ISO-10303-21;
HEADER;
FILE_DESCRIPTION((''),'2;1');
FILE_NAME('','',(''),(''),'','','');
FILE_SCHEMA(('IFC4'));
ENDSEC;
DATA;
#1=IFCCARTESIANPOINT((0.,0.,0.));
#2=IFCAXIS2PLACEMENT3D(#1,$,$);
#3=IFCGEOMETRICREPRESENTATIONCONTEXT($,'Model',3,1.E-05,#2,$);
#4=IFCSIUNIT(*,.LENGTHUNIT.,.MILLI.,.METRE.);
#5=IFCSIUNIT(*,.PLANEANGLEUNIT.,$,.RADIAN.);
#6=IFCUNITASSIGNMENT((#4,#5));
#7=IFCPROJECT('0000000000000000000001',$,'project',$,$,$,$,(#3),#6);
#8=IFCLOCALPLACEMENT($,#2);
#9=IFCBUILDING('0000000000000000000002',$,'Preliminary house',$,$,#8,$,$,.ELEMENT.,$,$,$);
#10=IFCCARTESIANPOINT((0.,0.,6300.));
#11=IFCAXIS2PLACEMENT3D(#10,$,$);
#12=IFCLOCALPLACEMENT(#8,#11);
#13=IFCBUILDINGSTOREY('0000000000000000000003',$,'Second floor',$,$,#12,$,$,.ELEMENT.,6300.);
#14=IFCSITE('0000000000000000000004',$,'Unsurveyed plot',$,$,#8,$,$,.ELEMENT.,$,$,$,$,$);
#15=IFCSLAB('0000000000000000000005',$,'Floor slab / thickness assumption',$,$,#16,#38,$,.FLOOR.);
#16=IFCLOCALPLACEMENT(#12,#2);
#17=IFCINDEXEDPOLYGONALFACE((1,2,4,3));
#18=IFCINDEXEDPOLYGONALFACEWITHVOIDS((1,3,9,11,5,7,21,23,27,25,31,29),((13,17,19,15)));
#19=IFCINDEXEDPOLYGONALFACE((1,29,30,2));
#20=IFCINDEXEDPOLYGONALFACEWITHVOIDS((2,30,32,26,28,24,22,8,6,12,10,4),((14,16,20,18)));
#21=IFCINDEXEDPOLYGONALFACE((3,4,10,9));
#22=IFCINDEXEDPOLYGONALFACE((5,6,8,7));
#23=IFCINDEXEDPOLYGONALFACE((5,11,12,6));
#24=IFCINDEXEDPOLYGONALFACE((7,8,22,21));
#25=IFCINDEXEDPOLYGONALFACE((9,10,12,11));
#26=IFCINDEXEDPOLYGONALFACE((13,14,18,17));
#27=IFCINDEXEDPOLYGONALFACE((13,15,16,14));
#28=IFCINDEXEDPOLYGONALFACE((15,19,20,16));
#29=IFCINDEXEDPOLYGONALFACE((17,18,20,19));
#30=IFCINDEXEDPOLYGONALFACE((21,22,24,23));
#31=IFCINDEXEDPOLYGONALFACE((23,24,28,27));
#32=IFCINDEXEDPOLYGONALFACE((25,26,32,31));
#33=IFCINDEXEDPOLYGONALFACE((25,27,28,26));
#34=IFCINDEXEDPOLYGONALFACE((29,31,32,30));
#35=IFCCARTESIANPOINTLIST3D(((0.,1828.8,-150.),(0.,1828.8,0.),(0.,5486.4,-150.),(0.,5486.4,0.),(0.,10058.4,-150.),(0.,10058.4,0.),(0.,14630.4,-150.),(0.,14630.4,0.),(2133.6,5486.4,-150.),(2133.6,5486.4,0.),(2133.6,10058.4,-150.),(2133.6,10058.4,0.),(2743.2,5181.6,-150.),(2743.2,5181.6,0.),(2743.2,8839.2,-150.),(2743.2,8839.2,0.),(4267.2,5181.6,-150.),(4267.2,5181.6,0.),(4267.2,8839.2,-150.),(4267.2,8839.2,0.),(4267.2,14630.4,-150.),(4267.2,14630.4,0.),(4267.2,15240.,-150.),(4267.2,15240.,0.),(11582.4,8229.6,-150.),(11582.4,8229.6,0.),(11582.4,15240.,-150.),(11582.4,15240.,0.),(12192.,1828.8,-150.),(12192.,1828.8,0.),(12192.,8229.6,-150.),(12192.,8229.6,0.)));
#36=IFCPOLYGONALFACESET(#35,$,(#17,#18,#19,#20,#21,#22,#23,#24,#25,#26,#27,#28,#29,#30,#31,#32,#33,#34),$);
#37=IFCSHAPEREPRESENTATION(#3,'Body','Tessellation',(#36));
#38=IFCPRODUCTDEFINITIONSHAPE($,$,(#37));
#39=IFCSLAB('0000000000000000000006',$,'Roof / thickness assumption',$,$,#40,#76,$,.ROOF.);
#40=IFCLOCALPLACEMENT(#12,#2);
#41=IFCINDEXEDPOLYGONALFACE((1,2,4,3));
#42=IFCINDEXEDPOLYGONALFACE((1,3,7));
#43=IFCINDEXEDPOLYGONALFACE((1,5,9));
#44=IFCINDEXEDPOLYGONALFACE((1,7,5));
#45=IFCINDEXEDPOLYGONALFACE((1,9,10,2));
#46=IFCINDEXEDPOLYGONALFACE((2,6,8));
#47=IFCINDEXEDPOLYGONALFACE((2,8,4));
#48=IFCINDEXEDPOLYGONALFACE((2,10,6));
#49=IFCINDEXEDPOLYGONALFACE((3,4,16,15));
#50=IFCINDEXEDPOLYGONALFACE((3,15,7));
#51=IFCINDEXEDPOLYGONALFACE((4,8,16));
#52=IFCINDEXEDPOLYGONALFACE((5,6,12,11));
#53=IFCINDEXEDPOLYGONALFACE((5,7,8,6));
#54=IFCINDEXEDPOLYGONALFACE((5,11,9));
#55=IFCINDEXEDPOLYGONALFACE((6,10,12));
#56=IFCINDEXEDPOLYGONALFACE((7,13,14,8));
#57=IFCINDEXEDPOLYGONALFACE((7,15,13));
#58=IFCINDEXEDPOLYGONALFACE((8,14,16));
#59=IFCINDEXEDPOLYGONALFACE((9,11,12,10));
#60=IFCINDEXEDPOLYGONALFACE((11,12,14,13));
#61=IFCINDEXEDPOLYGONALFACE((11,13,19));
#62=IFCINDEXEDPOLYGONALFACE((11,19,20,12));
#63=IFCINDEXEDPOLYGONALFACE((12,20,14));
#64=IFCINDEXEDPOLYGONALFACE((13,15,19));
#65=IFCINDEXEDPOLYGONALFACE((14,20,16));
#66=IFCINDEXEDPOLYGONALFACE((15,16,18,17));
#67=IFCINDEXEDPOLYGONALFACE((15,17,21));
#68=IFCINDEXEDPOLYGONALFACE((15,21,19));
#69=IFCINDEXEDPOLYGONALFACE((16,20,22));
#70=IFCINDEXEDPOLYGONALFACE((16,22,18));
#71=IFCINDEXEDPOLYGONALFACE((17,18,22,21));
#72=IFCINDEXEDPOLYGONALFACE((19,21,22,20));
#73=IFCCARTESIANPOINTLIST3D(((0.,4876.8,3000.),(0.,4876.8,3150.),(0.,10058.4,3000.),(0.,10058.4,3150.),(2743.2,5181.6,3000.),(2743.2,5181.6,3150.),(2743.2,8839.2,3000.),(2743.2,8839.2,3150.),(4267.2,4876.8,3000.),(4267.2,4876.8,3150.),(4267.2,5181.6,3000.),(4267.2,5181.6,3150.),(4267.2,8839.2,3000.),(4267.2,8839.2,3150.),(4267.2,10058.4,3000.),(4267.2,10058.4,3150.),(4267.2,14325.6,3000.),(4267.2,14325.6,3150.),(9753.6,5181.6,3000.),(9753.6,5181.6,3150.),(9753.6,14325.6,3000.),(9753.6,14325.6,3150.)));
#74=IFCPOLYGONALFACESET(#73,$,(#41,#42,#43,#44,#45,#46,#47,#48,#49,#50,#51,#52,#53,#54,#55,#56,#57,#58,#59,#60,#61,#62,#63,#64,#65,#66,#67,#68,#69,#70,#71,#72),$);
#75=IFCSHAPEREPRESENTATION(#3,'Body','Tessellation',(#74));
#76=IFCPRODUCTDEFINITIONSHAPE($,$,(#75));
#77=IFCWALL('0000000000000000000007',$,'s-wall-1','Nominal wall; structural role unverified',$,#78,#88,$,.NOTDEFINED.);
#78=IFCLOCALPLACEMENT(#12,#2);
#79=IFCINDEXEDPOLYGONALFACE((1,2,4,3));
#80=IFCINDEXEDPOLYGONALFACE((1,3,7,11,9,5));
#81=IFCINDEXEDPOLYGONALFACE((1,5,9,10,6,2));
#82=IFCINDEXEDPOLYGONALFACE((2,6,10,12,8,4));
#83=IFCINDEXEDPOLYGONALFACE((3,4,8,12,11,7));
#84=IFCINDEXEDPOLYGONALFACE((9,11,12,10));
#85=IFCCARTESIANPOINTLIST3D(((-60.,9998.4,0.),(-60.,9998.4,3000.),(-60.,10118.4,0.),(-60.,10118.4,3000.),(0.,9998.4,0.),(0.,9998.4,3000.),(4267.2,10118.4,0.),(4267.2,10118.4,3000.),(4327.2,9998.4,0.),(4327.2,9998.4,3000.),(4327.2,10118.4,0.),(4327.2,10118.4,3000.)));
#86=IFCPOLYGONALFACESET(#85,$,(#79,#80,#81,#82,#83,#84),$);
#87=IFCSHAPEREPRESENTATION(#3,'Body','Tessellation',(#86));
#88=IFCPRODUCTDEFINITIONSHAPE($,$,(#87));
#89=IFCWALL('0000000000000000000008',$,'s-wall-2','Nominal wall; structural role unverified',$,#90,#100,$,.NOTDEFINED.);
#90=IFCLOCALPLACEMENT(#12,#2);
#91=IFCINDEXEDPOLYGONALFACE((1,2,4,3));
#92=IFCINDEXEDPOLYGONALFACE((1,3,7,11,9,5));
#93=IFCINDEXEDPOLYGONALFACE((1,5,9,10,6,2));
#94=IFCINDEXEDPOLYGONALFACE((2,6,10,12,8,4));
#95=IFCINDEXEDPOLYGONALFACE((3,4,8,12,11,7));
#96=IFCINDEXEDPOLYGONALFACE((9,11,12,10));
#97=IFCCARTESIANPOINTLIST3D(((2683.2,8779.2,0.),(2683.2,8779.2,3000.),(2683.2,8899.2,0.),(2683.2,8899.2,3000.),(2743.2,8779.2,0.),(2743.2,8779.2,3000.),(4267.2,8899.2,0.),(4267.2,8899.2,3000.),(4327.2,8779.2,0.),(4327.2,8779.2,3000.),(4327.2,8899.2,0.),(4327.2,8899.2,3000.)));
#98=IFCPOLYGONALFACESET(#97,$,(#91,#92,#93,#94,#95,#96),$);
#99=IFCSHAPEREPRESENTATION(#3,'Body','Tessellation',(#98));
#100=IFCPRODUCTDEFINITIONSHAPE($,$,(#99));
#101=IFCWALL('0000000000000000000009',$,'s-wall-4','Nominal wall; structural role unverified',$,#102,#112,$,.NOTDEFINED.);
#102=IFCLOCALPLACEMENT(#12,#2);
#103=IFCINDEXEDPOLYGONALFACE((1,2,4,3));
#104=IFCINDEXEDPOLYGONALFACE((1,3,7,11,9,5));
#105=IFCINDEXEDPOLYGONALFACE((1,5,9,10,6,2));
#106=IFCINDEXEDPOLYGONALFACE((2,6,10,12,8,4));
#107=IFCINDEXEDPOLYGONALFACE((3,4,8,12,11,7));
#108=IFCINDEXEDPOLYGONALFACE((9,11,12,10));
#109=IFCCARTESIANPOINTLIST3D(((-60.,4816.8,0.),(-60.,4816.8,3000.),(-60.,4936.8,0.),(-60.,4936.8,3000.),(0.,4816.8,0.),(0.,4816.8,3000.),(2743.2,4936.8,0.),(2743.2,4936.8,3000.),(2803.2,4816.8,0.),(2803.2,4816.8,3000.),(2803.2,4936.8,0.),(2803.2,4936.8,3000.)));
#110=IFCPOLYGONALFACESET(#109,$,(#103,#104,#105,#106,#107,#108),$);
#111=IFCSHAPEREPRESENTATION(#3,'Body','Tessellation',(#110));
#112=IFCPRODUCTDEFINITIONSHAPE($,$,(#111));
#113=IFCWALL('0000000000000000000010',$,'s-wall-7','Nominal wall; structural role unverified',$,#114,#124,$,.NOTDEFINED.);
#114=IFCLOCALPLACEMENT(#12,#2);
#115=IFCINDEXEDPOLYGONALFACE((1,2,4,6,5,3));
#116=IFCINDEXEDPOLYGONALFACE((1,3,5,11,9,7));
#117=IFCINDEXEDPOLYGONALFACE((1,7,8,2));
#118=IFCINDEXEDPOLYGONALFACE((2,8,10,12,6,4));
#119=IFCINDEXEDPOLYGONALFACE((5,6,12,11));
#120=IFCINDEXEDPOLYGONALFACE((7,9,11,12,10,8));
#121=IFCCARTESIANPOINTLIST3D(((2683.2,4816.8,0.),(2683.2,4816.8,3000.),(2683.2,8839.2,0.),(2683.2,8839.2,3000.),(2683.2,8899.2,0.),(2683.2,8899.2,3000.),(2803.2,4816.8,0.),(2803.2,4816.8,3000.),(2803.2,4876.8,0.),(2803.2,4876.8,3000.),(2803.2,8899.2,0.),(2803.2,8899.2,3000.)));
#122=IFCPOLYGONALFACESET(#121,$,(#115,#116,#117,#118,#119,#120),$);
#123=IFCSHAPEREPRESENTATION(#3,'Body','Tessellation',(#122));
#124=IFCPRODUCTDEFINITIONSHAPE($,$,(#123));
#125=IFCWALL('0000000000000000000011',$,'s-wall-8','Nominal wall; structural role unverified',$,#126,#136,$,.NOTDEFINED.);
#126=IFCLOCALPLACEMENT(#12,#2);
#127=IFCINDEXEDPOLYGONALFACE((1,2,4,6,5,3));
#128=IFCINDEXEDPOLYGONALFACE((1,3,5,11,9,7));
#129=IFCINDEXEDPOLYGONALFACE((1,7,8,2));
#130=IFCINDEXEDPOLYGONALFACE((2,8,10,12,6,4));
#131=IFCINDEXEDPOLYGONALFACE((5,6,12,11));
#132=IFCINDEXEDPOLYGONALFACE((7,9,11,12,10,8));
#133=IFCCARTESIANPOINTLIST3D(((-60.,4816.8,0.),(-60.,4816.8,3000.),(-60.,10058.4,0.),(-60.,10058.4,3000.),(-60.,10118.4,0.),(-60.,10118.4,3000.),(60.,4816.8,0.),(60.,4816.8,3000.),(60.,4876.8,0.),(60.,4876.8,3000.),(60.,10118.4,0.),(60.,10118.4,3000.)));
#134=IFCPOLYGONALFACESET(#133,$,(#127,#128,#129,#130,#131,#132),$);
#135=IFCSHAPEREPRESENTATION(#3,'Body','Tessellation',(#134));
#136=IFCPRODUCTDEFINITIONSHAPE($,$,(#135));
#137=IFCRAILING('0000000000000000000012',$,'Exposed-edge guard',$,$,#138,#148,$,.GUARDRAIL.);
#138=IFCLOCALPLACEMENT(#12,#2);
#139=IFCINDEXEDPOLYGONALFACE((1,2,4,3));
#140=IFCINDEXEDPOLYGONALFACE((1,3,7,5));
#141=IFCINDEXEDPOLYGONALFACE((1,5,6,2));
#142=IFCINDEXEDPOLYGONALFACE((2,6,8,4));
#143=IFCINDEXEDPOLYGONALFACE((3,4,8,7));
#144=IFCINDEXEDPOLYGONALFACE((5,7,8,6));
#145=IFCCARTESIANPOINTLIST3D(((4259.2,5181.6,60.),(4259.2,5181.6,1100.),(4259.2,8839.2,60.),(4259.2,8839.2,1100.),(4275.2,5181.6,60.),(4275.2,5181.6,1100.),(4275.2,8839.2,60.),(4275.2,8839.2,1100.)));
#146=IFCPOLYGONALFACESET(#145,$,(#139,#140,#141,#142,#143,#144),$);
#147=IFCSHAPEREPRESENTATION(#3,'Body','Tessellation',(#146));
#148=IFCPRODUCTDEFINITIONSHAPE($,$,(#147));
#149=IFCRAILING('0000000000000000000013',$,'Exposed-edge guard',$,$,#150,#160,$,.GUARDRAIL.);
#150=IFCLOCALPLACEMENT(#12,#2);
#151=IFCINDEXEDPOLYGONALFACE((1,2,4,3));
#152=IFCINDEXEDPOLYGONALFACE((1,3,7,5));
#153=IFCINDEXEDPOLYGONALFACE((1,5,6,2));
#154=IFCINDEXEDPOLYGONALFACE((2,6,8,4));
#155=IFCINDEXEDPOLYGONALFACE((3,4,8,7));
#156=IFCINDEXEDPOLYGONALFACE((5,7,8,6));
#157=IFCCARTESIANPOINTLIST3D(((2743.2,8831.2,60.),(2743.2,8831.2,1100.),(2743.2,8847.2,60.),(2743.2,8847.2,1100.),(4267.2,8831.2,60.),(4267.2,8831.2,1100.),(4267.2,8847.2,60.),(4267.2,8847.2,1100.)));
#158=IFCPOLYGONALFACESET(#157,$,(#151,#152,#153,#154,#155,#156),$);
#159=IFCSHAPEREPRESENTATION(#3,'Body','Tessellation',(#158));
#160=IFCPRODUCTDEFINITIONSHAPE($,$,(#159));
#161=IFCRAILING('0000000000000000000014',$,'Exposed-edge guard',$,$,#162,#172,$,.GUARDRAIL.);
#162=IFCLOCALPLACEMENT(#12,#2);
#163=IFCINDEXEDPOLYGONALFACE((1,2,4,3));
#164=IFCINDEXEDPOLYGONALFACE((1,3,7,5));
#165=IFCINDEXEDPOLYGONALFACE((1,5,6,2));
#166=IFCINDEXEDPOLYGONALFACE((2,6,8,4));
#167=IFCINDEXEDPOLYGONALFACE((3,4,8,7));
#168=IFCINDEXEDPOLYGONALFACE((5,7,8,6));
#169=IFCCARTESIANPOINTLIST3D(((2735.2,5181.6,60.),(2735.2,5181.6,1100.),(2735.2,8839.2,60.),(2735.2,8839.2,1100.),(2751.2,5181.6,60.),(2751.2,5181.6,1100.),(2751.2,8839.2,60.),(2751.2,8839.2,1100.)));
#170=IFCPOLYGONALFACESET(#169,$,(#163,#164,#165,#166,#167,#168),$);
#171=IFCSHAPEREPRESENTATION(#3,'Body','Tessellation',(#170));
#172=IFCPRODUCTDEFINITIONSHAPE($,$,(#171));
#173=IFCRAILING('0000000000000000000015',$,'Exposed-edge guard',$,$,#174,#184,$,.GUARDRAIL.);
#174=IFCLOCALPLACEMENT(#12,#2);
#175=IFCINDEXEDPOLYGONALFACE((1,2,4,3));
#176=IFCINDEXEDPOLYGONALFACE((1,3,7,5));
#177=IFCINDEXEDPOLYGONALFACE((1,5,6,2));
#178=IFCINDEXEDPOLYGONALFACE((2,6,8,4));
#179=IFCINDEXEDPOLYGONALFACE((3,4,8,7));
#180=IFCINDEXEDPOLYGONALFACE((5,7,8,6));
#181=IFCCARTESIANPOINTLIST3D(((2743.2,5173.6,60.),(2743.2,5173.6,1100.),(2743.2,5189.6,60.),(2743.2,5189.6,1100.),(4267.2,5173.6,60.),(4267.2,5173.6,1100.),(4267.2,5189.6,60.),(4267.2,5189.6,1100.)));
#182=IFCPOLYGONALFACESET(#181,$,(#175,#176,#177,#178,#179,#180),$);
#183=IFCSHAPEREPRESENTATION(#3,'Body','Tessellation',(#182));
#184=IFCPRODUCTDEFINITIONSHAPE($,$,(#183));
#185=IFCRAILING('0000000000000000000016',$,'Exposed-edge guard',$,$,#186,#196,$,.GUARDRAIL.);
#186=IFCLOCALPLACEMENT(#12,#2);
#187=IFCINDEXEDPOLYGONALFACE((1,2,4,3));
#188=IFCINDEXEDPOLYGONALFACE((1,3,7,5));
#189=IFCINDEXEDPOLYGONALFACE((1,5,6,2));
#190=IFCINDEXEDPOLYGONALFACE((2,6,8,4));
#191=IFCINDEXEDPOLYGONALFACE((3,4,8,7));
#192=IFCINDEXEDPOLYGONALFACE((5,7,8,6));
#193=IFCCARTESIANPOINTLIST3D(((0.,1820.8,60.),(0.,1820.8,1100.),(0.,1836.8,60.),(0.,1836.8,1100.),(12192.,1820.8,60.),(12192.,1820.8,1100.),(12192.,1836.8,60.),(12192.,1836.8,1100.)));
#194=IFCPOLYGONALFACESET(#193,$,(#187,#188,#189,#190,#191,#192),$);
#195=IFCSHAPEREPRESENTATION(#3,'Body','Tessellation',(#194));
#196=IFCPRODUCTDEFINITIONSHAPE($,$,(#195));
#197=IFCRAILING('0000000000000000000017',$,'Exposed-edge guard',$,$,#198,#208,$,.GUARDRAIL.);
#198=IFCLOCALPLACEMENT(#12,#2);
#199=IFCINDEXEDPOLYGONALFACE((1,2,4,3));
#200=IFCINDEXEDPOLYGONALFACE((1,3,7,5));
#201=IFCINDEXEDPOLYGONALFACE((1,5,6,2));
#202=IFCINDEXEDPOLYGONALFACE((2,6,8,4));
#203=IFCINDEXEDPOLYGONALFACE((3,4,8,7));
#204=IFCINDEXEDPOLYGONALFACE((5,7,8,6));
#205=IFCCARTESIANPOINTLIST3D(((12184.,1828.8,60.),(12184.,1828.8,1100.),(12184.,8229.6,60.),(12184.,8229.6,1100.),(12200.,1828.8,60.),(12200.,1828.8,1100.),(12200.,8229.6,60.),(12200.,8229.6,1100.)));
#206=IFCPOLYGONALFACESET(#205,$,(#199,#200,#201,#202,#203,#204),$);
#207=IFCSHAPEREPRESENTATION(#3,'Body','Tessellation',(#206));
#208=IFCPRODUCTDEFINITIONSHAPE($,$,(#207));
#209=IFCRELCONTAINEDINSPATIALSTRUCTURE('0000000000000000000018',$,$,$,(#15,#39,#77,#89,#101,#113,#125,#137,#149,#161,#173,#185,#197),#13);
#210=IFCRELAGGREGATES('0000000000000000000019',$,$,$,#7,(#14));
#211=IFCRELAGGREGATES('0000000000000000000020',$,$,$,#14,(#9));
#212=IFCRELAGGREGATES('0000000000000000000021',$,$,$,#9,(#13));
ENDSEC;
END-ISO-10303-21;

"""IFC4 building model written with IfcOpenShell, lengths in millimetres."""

from ifc_helpers import new_model, si_unit, frame, origin, place, context, project, spatial, polyline, outline, extrude, element, save


model = new_model("IFC4")

# Units and contexts
model_context = context("Model", 3, precision=1e-05, world=origin())
ifc_project = project(units=[si_unit("LENGTHUNIT", "METRE", prefix="MILLI"), si_unit("PLANEANGLEUNIT", "RADIAN")], contexts=[model_context])

# Site, building, storey
placement_1 = place(None, origin())
site = spatial("IfcSite", under=ifc_project, at=placement_1, Name="Unsurveyed plot", CompositionType="ELEMENT")
building = spatial("IfcBuilding", under=site, at=placement_1, Name="Preliminary house", CompositionType="ELEMENT")
placement_2 = place(placement_1, frame((0.0, 0.0, 6300.0)))
storey = spatial("IfcBuildingStorey", under=building, at=placement_2, Name="Second floor", CompositionType="ELEMENT", Elevation=6300.0)

# Slabs
element("IfcSlab", 1, at=placement_2, inside=storey, Name="Floor slab / thickness assumption", PredefinedType="FLOOR", context=model_context, shape_type="SweptSolid", body=[
    extrude(outline(polyline([(0.0, 1828.8), (0.0, 5486.4), (2133.6, 5486.4), (2133.6, 10058.4), (0.0, 10058.4), (0.0, 14630.4), (4267.2, 14630.4), (4267.2, 15240.0), (11582.4, 15240.0), (11582.4, 8229.6), (12192.0, 8229.6), (12192.0, 1828.8), (0.0, 1828.8)]), holes=[polyline([(4267.2, 5181.6), (4267.2, 8839.2), (2743.2, 8839.2), (2743.2, 5181.6), (4267.2, 5181.6)])]), frame((0.0, 0.0, -150.0)), (0.0, 0.0, 1.0), 150.0),
])
element("IfcSlab", 2, at=placement_2, inside=storey, Name="Roof / thickness assumption", PredefinedType="ROOF", context=model_context, shape_type="SweptSolid", body=[
    extrude(outline(polyline([(0.0, 4876.8), (0.0, 10058.4), (4267.2, 10058.4), (4267.2, 14325.6), (9753.6, 14325.6), (9753.6, 5181.6), (4267.2, 5181.6), (4267.2, 4876.8), (0.0, 4876.8)]), holes=[polyline([(4267.2, 8839.2), (2743.2, 8839.2), (2743.2, 5181.6), (4267.2, 5181.6), (4267.2, 8839.2)])]), frame((0.0, 0.0, 3000.0)), (0.0, 0.0, 1.0), 150.0),
])

# Walls
element("IfcWall", 3, at=placement_2, inside=storey, Name="s-wall-1", Description="Nominal wall; structural role unverified", PredefinedType="NOTDEFINED", context=model_context, shape_type="SweptSolid", body=[
    extrude(outline(polyline([(4267.2, 10118.4), (4327.2, 10118.4), (4327.2, 9998.4), (0.0, 9998.4), (-60.0, 9998.4), (-60.0, 10118.4), (4267.2, 10118.4)])), origin(), (0.0, 0.0, 1.0), 3000.0),
])
element("IfcWall", 4, at=placement_2, inside=storey, Name="s-wall-2", Description="Nominal wall; structural role unverified", PredefinedType="NOTDEFINED", context=model_context, shape_type="SweptSolid", body=[
    extrude(outline(polyline([(4267.2, 8899.2), (4327.2, 8899.2), (4327.2, 8779.2), (2743.2, 8779.2), (2683.2, 8779.2), (2683.2, 8899.2), (4267.2, 8899.2)])), origin(), (0.0, 0.0, 1.0), 3000.0),
])

# Wall
element("IfcWall", 5, at=placement_2, inside=storey, Name="s-wall-4", Description="Nominal wall; structural role unverified", PredefinedType="NOTDEFINED", context=model_context, shape_type="SweptSolid", body=[
    extrude(outline(polyline([(2743.2, 4936.8), (2803.2, 4936.8), (2803.2, 4816.8), (0.0, 4816.8), (-60.0, 4816.8), (-60.0, 4936.8), (2743.2, 4936.8)])), origin(), (0.0, 0.0, 1.0), 3000.0),
])

# Walls
element("IfcWall", 6, at=placement_2, inside=storey, Name="s-wall-7", Description="Nominal wall; structural role unverified", PredefinedType="NOTDEFINED", context=model_context, shape_type="SweptSolid", body=[
    extrude(outline(polyline([(2683.2, 8839.2), (2683.2, 8899.2), (2803.2, 8899.2), (2803.2, 4876.8), (2803.2, 4816.8), (2683.2, 4816.8), (2683.2, 8839.2)])), origin(), (0.0, 0.0, 1.0), 3000.0),
])
element("IfcWall", 7, at=placement_2, inside=storey, Name="s-wall-8", Description="Nominal wall; structural role unverified", PredefinedType="NOTDEFINED", context=model_context, shape_type="SweptSolid", body=[
    extrude(outline(polyline([(-60.0, 10058.4), (-60.0, 10118.4), (60.0, 10118.4), (60.0, 4876.8), (60.0, 4816.8), (-60.0, 4816.8), (-60.0, 10058.4)])), origin(), (0.0, 0.0, 1.0), 3000.0),
])

# Railings
element("IfcRailing", 8, at=placement_2, inside=storey, Name="Exposed-edge guard", PredefinedType="GUARDRAIL", context=model_context, shape_type="SweptSolid", body=[
    extrude(outline(polyline([(4275.2, 5181.6), (4259.2, 5181.6), (4259.2, 8839.2), (4275.2, 8839.2), (4275.2, 5181.6)])), frame((0.0, 0.0, 60.0)), (0.0, 0.0, 1.0), 1040.0),
])
element("IfcRailing", 9, at=placement_2, inside=storey, Name="Exposed-edge guard", PredefinedType="GUARDRAIL", context=model_context, shape_type="SweptSolid", body=[
    extrude(outline(polyline([(2743.2, 8831.2), (2743.2, 8847.2), (4267.2, 8847.2), (4267.2, 8831.2), (2743.2, 8831.2)])), frame((0.0, 0.0, 60.0)), (0.0, 0.0, 1.0), 1040.0),
])
element("IfcRailing", 10, at=placement_2, inside=storey, Name="Exposed-edge guard", PredefinedType="GUARDRAIL", context=model_context, shape_type="SweptSolid", body=[
    extrude(outline(polyline([(2751.2, 5181.6), (2735.2, 5181.6), (2735.2, 8839.2), (2751.2, 8839.2), (2751.2, 5181.6)])), frame((0.0, 0.0, 60.0)), (0.0, 0.0, 1.0), 1040.0),
])
element("IfcRailing", 11, at=placement_2, inside=storey, Name="Exposed-edge guard", PredefinedType="GUARDRAIL", context=model_context, shape_type="SweptSolid", body=[
    extrude(outline(polyline([(2743.2, 5173.6), (2743.2, 5189.6), (4267.2, 5189.6), (4267.2, 5173.6), (2743.2, 5173.6)])), frame((0.0, 0.0, 60.0)), (0.0, 0.0, 1.0), 1040.0),
])
element("IfcRailing", 12, at=placement_2, inside=storey, Name="Exposed-edge guard", PredefinedType="GUARDRAIL", context=model_context, shape_type="SweptSolid", body=[
    extrude(outline(polyline([(0.0, 1820.8), (0.0, 1836.8), (12192.0, 1836.8), (12192.0, 1820.8), (0.0, 1820.8)])), frame((0.0, 0.0, 60.0)), (0.0, 0.0, 1.0), 1040.0),
])
element("IfcRailing", 13, at=placement_2, inside=storey, Name="Exposed-edge guard", PredefinedType="GUARDRAIL", context=model_context, shape_type="SweptSolid", body=[
    extrude(outline(polyline([(12200.0, 1828.8), (12184.0, 1828.8), (12184.0, 8229.6), (12200.0, 8229.6), (12200.0, 1828.8)])), frame((0.0, 0.0, 60.0)), (0.0, 0.0, 1.0), 1040.0),
])

save(model, "model.ifc")
